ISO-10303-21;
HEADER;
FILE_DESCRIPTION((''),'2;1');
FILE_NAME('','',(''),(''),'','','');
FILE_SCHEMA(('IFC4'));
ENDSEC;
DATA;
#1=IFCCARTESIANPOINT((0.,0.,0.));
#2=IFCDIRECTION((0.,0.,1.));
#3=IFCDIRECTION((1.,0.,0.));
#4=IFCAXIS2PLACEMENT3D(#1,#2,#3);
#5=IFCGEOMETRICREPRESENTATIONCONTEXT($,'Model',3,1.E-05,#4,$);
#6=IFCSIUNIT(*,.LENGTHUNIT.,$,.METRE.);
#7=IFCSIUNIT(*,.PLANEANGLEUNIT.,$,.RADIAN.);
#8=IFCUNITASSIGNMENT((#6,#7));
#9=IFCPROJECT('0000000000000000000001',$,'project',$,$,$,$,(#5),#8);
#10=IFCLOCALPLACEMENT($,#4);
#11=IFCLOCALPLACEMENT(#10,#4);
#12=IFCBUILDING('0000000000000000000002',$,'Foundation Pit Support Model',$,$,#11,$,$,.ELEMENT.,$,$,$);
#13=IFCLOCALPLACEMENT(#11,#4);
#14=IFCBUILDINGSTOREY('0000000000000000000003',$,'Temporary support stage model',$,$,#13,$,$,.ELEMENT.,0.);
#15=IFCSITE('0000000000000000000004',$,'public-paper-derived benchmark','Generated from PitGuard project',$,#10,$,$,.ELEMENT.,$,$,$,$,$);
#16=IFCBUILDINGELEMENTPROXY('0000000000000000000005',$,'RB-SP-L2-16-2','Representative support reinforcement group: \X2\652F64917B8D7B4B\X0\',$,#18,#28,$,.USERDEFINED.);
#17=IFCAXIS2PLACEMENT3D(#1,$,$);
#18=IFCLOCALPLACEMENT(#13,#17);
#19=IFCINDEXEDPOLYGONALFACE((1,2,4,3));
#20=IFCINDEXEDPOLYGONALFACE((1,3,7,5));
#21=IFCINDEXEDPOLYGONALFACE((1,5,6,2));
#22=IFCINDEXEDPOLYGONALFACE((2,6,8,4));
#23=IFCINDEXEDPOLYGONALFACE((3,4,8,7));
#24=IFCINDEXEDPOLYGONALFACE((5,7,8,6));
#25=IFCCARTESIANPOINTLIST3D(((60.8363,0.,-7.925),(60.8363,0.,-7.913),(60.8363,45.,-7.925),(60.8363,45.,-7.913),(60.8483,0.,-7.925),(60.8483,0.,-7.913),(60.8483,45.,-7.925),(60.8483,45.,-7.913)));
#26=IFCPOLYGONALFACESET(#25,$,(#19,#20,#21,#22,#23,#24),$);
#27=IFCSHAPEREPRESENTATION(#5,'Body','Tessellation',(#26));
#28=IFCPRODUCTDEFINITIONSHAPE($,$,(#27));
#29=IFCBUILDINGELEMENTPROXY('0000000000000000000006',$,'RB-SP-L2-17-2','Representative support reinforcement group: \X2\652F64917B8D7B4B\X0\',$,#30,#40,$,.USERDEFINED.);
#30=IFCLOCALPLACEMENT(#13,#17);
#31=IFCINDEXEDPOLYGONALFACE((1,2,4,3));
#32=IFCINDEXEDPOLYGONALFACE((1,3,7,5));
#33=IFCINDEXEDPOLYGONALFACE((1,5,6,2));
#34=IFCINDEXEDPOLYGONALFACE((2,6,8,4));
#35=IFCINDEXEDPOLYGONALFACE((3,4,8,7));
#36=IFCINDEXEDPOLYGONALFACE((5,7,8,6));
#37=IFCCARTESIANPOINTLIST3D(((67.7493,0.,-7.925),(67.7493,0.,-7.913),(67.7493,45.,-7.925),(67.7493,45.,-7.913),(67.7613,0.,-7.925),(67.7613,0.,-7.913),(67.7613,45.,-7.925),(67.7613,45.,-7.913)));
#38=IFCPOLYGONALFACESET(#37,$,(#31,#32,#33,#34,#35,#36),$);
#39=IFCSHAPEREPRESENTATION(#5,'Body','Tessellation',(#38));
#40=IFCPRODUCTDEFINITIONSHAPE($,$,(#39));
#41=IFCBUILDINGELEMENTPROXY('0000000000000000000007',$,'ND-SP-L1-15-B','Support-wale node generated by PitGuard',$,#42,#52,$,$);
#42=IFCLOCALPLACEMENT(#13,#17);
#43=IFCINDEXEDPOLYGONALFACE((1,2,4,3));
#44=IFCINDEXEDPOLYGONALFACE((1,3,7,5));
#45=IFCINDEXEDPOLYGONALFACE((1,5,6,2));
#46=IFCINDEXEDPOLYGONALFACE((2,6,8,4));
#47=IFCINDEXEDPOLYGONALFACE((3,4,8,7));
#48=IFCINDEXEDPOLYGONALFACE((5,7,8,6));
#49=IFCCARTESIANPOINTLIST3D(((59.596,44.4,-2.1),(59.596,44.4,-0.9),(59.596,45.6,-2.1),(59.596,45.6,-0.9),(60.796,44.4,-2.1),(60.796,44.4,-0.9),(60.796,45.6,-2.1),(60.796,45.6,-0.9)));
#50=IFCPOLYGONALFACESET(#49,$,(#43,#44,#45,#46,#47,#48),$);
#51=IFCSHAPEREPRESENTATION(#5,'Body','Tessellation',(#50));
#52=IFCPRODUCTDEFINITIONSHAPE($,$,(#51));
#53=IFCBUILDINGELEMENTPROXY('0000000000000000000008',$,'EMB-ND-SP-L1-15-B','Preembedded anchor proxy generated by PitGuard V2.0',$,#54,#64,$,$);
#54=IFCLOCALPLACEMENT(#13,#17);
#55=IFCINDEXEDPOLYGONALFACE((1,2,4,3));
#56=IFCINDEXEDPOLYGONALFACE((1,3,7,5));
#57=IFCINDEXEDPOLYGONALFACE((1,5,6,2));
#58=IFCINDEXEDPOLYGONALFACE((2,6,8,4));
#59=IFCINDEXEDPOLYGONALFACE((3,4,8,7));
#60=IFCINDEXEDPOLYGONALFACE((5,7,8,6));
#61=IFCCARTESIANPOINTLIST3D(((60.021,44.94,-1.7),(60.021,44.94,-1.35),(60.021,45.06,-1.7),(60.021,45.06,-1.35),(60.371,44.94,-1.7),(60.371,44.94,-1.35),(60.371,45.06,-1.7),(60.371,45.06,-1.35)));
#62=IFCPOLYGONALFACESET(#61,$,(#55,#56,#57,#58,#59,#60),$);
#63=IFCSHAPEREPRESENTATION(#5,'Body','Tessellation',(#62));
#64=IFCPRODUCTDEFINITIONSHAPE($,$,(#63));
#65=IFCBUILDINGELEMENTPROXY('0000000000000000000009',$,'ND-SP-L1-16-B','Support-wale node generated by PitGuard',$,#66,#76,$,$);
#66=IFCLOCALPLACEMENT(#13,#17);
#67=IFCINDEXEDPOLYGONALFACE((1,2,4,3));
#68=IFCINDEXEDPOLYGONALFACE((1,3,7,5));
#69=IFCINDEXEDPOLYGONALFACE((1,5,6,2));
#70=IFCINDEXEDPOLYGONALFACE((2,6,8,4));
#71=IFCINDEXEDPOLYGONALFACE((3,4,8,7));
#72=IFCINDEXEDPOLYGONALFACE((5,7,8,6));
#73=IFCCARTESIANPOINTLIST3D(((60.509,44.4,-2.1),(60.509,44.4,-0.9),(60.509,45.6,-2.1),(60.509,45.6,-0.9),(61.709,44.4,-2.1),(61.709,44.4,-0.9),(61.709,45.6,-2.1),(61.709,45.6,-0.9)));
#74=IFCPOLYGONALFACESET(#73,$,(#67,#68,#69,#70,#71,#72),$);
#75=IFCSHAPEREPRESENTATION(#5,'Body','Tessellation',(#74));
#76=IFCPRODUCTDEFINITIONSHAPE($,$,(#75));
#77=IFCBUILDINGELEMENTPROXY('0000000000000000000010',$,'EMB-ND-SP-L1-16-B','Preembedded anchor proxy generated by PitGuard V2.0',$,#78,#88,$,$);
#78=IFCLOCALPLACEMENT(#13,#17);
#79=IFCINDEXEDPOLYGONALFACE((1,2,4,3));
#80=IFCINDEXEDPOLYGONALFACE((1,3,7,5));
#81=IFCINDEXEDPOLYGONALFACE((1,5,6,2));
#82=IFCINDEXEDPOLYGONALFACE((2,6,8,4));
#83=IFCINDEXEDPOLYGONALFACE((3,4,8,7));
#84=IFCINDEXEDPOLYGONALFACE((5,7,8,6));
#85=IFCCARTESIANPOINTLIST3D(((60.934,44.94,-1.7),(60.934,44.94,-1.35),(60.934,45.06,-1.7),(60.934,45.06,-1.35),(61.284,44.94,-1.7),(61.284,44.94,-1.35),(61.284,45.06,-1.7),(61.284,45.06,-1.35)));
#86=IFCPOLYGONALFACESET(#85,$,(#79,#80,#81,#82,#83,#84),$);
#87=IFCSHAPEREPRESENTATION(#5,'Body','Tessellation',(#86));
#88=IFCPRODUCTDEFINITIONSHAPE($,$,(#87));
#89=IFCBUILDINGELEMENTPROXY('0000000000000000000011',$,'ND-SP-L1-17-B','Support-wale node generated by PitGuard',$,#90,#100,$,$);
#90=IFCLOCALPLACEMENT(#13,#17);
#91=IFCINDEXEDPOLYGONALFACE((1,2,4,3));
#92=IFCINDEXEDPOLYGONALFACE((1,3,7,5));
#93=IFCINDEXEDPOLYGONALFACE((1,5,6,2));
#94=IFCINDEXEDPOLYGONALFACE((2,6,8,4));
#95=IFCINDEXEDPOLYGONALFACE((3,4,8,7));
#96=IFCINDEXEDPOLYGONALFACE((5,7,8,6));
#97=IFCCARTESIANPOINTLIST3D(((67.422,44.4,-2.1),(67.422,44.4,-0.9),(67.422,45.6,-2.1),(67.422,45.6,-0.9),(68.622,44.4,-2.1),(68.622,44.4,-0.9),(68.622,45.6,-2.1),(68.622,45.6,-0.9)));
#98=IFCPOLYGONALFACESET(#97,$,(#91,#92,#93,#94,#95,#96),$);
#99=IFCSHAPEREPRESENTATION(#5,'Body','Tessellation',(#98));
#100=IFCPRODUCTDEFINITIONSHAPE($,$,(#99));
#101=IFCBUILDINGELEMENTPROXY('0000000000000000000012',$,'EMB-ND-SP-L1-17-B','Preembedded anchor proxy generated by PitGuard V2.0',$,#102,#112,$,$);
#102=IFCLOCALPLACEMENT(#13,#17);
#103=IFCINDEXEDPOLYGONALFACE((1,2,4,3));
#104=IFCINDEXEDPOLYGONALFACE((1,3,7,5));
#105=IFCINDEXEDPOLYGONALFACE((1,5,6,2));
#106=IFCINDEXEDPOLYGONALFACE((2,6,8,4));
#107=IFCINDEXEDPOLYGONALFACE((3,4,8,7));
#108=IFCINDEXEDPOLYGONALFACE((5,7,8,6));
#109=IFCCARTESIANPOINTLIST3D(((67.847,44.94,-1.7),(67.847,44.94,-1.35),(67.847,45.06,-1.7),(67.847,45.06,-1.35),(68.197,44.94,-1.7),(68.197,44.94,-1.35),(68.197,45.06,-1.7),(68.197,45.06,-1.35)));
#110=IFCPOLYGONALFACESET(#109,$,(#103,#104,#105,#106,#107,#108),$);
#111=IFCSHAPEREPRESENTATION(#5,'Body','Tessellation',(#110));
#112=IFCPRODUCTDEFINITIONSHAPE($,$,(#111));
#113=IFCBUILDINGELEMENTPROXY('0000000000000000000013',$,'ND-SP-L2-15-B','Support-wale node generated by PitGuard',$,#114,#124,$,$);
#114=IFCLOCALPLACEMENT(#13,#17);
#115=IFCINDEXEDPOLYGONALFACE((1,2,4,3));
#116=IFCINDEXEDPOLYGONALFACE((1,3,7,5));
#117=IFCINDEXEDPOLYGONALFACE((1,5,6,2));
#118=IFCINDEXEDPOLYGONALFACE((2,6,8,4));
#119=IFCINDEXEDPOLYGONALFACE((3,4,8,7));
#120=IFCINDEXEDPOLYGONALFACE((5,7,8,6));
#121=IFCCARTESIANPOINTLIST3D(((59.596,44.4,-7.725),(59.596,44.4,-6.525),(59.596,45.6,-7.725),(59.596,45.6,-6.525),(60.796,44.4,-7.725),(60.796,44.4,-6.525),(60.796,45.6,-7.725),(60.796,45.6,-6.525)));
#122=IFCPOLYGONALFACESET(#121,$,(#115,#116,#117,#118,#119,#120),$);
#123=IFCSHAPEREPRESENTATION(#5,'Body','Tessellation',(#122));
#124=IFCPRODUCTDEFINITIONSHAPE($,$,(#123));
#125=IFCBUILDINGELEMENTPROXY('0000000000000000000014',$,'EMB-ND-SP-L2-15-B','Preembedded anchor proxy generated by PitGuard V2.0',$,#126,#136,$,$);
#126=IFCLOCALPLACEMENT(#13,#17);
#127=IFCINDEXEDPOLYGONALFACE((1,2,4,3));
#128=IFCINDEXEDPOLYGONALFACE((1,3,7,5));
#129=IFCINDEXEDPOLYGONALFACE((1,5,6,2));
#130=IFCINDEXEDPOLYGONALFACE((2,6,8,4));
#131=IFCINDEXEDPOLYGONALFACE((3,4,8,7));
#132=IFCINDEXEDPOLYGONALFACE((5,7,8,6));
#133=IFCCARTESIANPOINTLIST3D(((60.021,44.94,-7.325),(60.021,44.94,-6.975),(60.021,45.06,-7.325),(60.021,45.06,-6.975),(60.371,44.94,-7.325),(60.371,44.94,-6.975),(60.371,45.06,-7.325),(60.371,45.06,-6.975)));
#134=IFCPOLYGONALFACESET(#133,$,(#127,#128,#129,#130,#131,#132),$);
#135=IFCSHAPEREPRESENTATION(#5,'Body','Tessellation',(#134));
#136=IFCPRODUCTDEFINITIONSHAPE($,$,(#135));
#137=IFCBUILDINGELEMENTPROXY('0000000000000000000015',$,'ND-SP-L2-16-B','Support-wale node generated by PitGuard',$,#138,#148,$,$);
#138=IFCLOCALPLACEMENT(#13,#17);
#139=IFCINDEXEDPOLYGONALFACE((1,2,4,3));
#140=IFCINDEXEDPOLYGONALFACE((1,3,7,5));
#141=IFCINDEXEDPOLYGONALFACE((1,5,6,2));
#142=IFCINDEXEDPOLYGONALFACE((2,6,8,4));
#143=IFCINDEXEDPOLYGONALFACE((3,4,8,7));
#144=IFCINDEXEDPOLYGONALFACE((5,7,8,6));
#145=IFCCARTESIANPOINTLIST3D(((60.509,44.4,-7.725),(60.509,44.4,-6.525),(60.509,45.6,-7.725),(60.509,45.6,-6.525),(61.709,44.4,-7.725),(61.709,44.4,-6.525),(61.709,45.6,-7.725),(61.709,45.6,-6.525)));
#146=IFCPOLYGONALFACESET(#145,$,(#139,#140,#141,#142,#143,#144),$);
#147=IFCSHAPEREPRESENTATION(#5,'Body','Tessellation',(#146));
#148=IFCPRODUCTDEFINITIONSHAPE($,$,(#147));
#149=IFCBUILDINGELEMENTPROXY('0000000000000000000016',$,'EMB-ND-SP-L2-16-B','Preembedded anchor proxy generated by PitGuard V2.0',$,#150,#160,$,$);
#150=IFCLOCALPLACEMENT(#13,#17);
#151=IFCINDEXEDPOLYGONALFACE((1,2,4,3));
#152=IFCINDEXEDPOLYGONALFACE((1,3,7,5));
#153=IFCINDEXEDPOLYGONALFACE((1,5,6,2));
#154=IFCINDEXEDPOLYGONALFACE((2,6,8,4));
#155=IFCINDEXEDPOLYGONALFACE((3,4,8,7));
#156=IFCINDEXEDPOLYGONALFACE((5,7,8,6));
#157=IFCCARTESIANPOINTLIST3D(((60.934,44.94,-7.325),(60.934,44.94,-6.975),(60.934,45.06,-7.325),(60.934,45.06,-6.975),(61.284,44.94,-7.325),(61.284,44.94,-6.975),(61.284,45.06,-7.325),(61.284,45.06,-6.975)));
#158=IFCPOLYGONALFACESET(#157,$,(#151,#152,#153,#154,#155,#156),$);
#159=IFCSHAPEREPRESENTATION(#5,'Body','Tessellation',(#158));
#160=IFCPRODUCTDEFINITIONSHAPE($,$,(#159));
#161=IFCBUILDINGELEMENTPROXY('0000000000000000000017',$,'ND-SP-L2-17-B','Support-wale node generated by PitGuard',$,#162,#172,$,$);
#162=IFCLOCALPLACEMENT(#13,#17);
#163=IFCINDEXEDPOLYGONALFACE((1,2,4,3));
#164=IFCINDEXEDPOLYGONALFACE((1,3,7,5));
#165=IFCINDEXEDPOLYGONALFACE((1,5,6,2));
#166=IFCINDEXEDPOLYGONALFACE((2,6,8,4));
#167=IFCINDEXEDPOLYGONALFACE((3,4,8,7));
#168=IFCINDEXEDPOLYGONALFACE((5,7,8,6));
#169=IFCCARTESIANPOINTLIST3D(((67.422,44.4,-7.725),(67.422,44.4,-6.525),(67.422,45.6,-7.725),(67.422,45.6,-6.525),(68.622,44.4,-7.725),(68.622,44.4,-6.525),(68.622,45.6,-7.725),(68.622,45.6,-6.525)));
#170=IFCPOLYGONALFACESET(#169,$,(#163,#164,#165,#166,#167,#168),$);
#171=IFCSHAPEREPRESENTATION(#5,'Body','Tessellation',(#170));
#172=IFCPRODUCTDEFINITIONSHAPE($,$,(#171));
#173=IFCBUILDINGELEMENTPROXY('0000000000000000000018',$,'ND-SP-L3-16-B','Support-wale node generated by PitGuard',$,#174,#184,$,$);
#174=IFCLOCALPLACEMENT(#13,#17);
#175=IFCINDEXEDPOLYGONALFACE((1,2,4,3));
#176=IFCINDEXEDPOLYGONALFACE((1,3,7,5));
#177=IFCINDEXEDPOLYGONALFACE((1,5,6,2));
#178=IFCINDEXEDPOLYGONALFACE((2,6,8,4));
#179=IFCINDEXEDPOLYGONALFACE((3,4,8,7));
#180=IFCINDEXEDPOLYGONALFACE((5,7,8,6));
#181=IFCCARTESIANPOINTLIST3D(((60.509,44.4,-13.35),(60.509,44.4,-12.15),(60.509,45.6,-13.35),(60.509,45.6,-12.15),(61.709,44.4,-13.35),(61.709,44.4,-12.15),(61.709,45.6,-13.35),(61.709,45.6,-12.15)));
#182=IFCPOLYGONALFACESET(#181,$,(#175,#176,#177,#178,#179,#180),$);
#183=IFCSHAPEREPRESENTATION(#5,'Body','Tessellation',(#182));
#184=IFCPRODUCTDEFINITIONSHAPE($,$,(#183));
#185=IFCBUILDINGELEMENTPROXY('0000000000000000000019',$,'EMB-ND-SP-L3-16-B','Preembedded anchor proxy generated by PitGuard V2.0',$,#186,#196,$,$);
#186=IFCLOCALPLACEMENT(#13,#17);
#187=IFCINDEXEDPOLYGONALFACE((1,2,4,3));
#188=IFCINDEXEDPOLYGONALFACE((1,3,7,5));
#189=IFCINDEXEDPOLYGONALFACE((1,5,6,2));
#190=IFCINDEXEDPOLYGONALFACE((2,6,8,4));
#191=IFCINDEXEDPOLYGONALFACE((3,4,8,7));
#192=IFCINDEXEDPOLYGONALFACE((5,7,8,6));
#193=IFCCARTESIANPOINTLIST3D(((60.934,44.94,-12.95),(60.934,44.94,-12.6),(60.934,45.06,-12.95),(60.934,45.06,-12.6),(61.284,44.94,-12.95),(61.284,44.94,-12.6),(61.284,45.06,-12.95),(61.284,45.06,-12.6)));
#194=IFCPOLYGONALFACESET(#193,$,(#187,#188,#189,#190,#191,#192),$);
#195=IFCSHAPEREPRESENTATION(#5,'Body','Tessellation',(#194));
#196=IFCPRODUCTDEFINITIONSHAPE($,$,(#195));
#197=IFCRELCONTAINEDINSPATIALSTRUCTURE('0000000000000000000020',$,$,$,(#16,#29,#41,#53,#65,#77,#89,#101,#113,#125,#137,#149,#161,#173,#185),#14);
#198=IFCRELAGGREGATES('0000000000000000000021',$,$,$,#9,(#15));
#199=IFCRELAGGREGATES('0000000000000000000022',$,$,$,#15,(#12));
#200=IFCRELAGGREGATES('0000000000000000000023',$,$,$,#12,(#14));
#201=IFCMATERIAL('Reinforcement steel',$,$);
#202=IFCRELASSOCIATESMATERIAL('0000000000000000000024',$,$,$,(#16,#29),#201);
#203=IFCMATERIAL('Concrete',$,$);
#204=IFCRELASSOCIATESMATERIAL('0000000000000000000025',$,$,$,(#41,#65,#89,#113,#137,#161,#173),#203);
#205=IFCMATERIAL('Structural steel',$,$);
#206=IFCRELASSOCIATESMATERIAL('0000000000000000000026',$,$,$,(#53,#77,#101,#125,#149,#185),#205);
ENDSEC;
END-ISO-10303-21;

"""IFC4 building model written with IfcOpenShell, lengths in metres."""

from ifc_helpers import new_model, si_unit, frame, origin_with_axes, origin_2d, place, context, project, spatial, rectangle, extrude, material, element, save


model = new_model("IFC4")

# Units and contexts
model_context = context("Model", 3, precision=1e-05, world=origin_with_axes())
ifc_project = project(units=[si_unit("LENGTHUNIT", "METRE"), si_unit("PLANEANGLEUNIT", "RADIAN")], contexts=[model_context])

# Site, building, storey
site_placement = place(None, origin_with_axes())
site = spatial("IfcSite", under=ifc_project, at=site_placement, Name="public-paper-derived benchmark", Description="Generated from PitGuard project", CompositionType="ELEMENT")
building_placement = place(site_placement, origin_with_axes())
building = spatial("IfcBuilding", under=site, at=building_placement, Name="Foundation Pit Support Model", CompositionType="ELEMENT")
storey_placement = place(building_placement, origin_with_axes())
storey = spatial("IfcBuildingStorey", under=building, at=storey_placement, Name="Temporary support stage model", CompositionType="ELEMENT", Elevation=0.0)

# Shared definitions
ifc_material_1 = material(Name="Concrete")

# Shared definitions
ifc_material_2 = material(Name="Structural steel")

# Building element proxies
ifc_material_3 = material(Name="Reinforcement steel")
for number, where, z_axis, x_axis, name in (
    (1, (60.8423, 22.5, -7.925), (0.0, 0.0, 1.0), (0.0, 1.0, 0.0), "RB-SP-L2-16-2"),
    (2, (67.7553, 22.5, -7.925), (0.0, 0.0, 1.0), (0.0, 1.0, 0.0), "RB-SP-L2-17-2"),
):
    element("IfcBuildingElementProxy", number, at=place(storey_placement, frame(where, z_axis=z_axis, x_axis=x_axis)), inside=storey, material=ifc_material_3, Name=name, Description="Representative support reinforcement group: 支撑箍筋", PredefinedType="USERDEFINED", context=model_context, shape_type="SweptSolid", body=[
        extrude(rectangle(XDim=45.0, YDim=0.012, at=origin_2d()), origin_with_axes(), (0.0, 0.0, 1.0), 0.012),
    ])
proxy_1_placement = place(storey_placement, frame((60.196, 45.0, -2.1), z_axis=(0.0, 0.0, 1.0), x_axis=(1.0, 0.0, 0.0)))
element("IfcBuildingElementProxy", 3, at=proxy_1_placement, inside=storey, material=ifc_material_1, Name="ND-SP-L1-15-B", Description="Support-wale node generated by PitGuard", context=model_context, shape_type="SweptSolid", body=[
    extrude(rectangle(XDim=1.2, YDim=1.2, at=origin_2d()), origin_with_axes(), (0.0, 0.0, 1.0), 1.2),
])
proxy_2_placement = place(storey_placement, frame((60.196, 45.0, -1.7), z_axis=(0.0, 0.0, 1.0), x_axis=(1.0, 0.0, 0.0)))
element("IfcBuildingElementProxy", 4, at=proxy_2_placement, inside=storey, material=ifc_material_2, Name="EMB-ND-SP-L1-15-B", Description="Preembedded anchor proxy generated by PitGuard V2.0", context=model_context, shape_type="SweptSolid", body=[
    extrude(rectangle(XDim=0.35, YDim=0.12, at=origin_2d()), origin_with_axes(), (0.0, 0.0, 1.0), 0.35),
])
proxy_3_placement = place(storey_placement, frame((61.109, 45.0, -2.1), z_axis=(0.0, 0.0, 1.0), x_axis=(1.0, 0.0, 0.0)))
element("IfcBuildingElementProxy", 5, at=proxy_3_placement, inside=storey, material=ifc_material_1, Name="ND-SP-L1-16-B", Description="Support-wale node generated by PitGuard", context=model_context, shape_type="SweptSolid", body=[
    extrude(rectangle(XDim=1.2, YDim=1.2, at=origin_2d()), origin_with_axes(), (0.0, 0.0, 1.0), 1.2),
])
proxy_4_placement = place(storey_placement, frame((61.109, 45.0, -1.7), z_axis=(0.0, 0.0, 1.0), x_axis=(1.0, 0.0, 0.0)))
element("IfcBuildingElementProxy", 6, at=proxy_4_placement, inside=storey, material=ifc_material_2, Name="EMB-ND-SP-L1-16-B", Description="Preembedded anchor proxy generated by PitGuard V2.0", context=model_context, shape_type="SweptSolid", body=[
    extrude(rectangle(XDim=0.35, YDim=0.12, at=origin_2d()), origin_with_axes(), (0.0, 0.0, 1.0), 0.35),
])
proxy_5_placement = place(storey_placement, frame((68.022, 45.0, -2.1), z_axis=(0.0, 0.0, 1.0), x_axis=(1.0, 0.0, 0.0)))
element("IfcBuildingElementProxy", 7, at=proxy_5_placement, inside=storey, material=ifc_material_1, Name="ND-SP-L1-17-B", Description="Support-wale node generated by PitGuard", context=model_context, shape_type="SweptSolid", body=[
    extrude(rectangle(XDim=1.2, YDim=1.2, at=origin_2d()), origin_with_axes(), (0.0, 0.0, 1.0), 1.2),
])
proxy_6_placement = place(storey_placement, frame((68.022, 45.0, -1.7), z_axis=(0.0, 0.0, 1.0), x_axis=(1.0, 0.0, 0.0)))
element("IfcBuildingElementProxy", 8, at=proxy_6_placement, inside=storey, material=ifc_material_2, Name="EMB-ND-SP-L1-17-B", Description="Preembedded anchor proxy generated by PitGuard V2.0", context=model_context, shape_type="SweptSolid", body=[
    extrude(rectangle(XDim=0.35, YDim=0.12, at=origin_2d()), origin_with_axes(), (0.0, 0.0, 1.0), 0.35),
])
proxy_7_placement = place(storey_placement, frame((60.196, 45.0, -7.725), z_axis=(0.0, 0.0, 1.0), x_axis=(1.0, 0.0, 0.0)))
element("IfcBuildingElementProxy", 9, at=proxy_7_placement, inside=storey, material=ifc_material_1, Name="ND-SP-L2-15-B", Description="Support-wale node generated by PitGuard", context=model_context, shape_type="SweptSolid", body=[
    extrude(rectangle(XDim=1.2, YDim=1.2, at=origin_2d()), origin_with_axes(), (0.0, 0.0, 1.0), 1.2),
])
proxy_8_placement = place(storey_placement, frame((60.196, 45.0, -7.325), z_axis=(0.0, 0.0, 1.0), x_axis=(1.0, 0.0, 0.0)))
element("IfcBuildingElementProxy", 10, at=proxy_8_placement, inside=storey, material=ifc_material_2, Name="EMB-ND-SP-L2-15-B", Description="Preembedded anchor proxy generated by PitGuard V2.0", context=model_context, shape_type="SweptSolid", body=[
    extrude(rectangle(XDim=0.35, YDim=0.12, at=origin_2d()), origin_with_axes(), (0.0, 0.0, 1.0), 0.35),
])
proxy_9_placement = place(storey_placement, frame((61.109, 45.0, -7.725), z_axis=(0.0, 0.0, 1.0), x_axis=(1.0, 0.0, 0.0)))
element("IfcBuildingElementProxy", 11, at=proxy_9_placement, inside=storey, material=ifc_material_1, Name="ND-SP-L2-16-B", Description="Support-wale node generated by PitGuard", context=model_context, shape_type="SweptSolid", body=[
    extrude(rectangle(XDim=1.2, YDim=1.2, at=origin_2d()), origin_with_axes(), (0.0, 0.0, 1.0), 1.2),
])
proxy_10_placement = place(storey_placement, frame((61.109, 45.0, -7.325), z_axis=(0.0, 0.0, 1.0), x_axis=(1.0, 0.0, 0.0)))
element("IfcBuildingElementProxy", 12, at=proxy_10_placement, inside=storey, material=ifc_material_2, Name="EMB-ND-SP-L2-16-B", Description="Preembedded anchor proxy generated by PitGuard V2.0", context=model_context, shape_type="SweptSolid", body=[
    extrude(rectangle(XDim=0.35, YDim=0.12, at=origin_2d()), origin_with_axes(), (0.0, 0.0, 1.0), 0.35),
])
for number, where, z_axis, x_axis, name in (
    (13, (68.022, 45.0, -7.725), (0.0, 0.0, 1.0), (1.0, 0.0, 0.0), "ND-SP-L2-17-B"),
    (14, (61.109, 45.0, -13.35), (0.0, 0.0, 1.0), (1.0, 0.0, 0.0), "ND-SP-L3-16-B"),
):
    element("IfcBuildingElementProxy", number, at=place(storey_placement, frame(where, z_axis=z_axis, x_axis=x_axis)), inside=storey, material=ifc_material_1, Name=name, Description="Support-wale node generated by PitGuard", context=model_context, shape_type="SweptSolid", body=[
        extrude(rectangle(XDim=1.2, YDim=1.2, at=origin_2d()), origin_with_axes(), (0.0, 0.0, 1.0), 1.2),
    ])
proxy_11_placement = place(storey_placement, frame((61.109, 45.0, -12.95), z_axis=(0.0, 0.0, 1.0), x_axis=(1.0, 0.0, 0.0)))
element("IfcBuildingElementProxy", 15, at=proxy_11_placement, inside=storey, material=ifc_material_2, Name="EMB-ND-SP-L3-16-B", Description="Preembedded anchor proxy generated by PitGuard V2.0", context=model_context, shape_type="SweptSolid", body=[
    extrude(rectangle(XDim=0.35, YDim=0.12, at=origin_2d()), origin_with_axes(), (0.0, 0.0, 1.0), 0.35),
])

save(model, "model.ifc")
